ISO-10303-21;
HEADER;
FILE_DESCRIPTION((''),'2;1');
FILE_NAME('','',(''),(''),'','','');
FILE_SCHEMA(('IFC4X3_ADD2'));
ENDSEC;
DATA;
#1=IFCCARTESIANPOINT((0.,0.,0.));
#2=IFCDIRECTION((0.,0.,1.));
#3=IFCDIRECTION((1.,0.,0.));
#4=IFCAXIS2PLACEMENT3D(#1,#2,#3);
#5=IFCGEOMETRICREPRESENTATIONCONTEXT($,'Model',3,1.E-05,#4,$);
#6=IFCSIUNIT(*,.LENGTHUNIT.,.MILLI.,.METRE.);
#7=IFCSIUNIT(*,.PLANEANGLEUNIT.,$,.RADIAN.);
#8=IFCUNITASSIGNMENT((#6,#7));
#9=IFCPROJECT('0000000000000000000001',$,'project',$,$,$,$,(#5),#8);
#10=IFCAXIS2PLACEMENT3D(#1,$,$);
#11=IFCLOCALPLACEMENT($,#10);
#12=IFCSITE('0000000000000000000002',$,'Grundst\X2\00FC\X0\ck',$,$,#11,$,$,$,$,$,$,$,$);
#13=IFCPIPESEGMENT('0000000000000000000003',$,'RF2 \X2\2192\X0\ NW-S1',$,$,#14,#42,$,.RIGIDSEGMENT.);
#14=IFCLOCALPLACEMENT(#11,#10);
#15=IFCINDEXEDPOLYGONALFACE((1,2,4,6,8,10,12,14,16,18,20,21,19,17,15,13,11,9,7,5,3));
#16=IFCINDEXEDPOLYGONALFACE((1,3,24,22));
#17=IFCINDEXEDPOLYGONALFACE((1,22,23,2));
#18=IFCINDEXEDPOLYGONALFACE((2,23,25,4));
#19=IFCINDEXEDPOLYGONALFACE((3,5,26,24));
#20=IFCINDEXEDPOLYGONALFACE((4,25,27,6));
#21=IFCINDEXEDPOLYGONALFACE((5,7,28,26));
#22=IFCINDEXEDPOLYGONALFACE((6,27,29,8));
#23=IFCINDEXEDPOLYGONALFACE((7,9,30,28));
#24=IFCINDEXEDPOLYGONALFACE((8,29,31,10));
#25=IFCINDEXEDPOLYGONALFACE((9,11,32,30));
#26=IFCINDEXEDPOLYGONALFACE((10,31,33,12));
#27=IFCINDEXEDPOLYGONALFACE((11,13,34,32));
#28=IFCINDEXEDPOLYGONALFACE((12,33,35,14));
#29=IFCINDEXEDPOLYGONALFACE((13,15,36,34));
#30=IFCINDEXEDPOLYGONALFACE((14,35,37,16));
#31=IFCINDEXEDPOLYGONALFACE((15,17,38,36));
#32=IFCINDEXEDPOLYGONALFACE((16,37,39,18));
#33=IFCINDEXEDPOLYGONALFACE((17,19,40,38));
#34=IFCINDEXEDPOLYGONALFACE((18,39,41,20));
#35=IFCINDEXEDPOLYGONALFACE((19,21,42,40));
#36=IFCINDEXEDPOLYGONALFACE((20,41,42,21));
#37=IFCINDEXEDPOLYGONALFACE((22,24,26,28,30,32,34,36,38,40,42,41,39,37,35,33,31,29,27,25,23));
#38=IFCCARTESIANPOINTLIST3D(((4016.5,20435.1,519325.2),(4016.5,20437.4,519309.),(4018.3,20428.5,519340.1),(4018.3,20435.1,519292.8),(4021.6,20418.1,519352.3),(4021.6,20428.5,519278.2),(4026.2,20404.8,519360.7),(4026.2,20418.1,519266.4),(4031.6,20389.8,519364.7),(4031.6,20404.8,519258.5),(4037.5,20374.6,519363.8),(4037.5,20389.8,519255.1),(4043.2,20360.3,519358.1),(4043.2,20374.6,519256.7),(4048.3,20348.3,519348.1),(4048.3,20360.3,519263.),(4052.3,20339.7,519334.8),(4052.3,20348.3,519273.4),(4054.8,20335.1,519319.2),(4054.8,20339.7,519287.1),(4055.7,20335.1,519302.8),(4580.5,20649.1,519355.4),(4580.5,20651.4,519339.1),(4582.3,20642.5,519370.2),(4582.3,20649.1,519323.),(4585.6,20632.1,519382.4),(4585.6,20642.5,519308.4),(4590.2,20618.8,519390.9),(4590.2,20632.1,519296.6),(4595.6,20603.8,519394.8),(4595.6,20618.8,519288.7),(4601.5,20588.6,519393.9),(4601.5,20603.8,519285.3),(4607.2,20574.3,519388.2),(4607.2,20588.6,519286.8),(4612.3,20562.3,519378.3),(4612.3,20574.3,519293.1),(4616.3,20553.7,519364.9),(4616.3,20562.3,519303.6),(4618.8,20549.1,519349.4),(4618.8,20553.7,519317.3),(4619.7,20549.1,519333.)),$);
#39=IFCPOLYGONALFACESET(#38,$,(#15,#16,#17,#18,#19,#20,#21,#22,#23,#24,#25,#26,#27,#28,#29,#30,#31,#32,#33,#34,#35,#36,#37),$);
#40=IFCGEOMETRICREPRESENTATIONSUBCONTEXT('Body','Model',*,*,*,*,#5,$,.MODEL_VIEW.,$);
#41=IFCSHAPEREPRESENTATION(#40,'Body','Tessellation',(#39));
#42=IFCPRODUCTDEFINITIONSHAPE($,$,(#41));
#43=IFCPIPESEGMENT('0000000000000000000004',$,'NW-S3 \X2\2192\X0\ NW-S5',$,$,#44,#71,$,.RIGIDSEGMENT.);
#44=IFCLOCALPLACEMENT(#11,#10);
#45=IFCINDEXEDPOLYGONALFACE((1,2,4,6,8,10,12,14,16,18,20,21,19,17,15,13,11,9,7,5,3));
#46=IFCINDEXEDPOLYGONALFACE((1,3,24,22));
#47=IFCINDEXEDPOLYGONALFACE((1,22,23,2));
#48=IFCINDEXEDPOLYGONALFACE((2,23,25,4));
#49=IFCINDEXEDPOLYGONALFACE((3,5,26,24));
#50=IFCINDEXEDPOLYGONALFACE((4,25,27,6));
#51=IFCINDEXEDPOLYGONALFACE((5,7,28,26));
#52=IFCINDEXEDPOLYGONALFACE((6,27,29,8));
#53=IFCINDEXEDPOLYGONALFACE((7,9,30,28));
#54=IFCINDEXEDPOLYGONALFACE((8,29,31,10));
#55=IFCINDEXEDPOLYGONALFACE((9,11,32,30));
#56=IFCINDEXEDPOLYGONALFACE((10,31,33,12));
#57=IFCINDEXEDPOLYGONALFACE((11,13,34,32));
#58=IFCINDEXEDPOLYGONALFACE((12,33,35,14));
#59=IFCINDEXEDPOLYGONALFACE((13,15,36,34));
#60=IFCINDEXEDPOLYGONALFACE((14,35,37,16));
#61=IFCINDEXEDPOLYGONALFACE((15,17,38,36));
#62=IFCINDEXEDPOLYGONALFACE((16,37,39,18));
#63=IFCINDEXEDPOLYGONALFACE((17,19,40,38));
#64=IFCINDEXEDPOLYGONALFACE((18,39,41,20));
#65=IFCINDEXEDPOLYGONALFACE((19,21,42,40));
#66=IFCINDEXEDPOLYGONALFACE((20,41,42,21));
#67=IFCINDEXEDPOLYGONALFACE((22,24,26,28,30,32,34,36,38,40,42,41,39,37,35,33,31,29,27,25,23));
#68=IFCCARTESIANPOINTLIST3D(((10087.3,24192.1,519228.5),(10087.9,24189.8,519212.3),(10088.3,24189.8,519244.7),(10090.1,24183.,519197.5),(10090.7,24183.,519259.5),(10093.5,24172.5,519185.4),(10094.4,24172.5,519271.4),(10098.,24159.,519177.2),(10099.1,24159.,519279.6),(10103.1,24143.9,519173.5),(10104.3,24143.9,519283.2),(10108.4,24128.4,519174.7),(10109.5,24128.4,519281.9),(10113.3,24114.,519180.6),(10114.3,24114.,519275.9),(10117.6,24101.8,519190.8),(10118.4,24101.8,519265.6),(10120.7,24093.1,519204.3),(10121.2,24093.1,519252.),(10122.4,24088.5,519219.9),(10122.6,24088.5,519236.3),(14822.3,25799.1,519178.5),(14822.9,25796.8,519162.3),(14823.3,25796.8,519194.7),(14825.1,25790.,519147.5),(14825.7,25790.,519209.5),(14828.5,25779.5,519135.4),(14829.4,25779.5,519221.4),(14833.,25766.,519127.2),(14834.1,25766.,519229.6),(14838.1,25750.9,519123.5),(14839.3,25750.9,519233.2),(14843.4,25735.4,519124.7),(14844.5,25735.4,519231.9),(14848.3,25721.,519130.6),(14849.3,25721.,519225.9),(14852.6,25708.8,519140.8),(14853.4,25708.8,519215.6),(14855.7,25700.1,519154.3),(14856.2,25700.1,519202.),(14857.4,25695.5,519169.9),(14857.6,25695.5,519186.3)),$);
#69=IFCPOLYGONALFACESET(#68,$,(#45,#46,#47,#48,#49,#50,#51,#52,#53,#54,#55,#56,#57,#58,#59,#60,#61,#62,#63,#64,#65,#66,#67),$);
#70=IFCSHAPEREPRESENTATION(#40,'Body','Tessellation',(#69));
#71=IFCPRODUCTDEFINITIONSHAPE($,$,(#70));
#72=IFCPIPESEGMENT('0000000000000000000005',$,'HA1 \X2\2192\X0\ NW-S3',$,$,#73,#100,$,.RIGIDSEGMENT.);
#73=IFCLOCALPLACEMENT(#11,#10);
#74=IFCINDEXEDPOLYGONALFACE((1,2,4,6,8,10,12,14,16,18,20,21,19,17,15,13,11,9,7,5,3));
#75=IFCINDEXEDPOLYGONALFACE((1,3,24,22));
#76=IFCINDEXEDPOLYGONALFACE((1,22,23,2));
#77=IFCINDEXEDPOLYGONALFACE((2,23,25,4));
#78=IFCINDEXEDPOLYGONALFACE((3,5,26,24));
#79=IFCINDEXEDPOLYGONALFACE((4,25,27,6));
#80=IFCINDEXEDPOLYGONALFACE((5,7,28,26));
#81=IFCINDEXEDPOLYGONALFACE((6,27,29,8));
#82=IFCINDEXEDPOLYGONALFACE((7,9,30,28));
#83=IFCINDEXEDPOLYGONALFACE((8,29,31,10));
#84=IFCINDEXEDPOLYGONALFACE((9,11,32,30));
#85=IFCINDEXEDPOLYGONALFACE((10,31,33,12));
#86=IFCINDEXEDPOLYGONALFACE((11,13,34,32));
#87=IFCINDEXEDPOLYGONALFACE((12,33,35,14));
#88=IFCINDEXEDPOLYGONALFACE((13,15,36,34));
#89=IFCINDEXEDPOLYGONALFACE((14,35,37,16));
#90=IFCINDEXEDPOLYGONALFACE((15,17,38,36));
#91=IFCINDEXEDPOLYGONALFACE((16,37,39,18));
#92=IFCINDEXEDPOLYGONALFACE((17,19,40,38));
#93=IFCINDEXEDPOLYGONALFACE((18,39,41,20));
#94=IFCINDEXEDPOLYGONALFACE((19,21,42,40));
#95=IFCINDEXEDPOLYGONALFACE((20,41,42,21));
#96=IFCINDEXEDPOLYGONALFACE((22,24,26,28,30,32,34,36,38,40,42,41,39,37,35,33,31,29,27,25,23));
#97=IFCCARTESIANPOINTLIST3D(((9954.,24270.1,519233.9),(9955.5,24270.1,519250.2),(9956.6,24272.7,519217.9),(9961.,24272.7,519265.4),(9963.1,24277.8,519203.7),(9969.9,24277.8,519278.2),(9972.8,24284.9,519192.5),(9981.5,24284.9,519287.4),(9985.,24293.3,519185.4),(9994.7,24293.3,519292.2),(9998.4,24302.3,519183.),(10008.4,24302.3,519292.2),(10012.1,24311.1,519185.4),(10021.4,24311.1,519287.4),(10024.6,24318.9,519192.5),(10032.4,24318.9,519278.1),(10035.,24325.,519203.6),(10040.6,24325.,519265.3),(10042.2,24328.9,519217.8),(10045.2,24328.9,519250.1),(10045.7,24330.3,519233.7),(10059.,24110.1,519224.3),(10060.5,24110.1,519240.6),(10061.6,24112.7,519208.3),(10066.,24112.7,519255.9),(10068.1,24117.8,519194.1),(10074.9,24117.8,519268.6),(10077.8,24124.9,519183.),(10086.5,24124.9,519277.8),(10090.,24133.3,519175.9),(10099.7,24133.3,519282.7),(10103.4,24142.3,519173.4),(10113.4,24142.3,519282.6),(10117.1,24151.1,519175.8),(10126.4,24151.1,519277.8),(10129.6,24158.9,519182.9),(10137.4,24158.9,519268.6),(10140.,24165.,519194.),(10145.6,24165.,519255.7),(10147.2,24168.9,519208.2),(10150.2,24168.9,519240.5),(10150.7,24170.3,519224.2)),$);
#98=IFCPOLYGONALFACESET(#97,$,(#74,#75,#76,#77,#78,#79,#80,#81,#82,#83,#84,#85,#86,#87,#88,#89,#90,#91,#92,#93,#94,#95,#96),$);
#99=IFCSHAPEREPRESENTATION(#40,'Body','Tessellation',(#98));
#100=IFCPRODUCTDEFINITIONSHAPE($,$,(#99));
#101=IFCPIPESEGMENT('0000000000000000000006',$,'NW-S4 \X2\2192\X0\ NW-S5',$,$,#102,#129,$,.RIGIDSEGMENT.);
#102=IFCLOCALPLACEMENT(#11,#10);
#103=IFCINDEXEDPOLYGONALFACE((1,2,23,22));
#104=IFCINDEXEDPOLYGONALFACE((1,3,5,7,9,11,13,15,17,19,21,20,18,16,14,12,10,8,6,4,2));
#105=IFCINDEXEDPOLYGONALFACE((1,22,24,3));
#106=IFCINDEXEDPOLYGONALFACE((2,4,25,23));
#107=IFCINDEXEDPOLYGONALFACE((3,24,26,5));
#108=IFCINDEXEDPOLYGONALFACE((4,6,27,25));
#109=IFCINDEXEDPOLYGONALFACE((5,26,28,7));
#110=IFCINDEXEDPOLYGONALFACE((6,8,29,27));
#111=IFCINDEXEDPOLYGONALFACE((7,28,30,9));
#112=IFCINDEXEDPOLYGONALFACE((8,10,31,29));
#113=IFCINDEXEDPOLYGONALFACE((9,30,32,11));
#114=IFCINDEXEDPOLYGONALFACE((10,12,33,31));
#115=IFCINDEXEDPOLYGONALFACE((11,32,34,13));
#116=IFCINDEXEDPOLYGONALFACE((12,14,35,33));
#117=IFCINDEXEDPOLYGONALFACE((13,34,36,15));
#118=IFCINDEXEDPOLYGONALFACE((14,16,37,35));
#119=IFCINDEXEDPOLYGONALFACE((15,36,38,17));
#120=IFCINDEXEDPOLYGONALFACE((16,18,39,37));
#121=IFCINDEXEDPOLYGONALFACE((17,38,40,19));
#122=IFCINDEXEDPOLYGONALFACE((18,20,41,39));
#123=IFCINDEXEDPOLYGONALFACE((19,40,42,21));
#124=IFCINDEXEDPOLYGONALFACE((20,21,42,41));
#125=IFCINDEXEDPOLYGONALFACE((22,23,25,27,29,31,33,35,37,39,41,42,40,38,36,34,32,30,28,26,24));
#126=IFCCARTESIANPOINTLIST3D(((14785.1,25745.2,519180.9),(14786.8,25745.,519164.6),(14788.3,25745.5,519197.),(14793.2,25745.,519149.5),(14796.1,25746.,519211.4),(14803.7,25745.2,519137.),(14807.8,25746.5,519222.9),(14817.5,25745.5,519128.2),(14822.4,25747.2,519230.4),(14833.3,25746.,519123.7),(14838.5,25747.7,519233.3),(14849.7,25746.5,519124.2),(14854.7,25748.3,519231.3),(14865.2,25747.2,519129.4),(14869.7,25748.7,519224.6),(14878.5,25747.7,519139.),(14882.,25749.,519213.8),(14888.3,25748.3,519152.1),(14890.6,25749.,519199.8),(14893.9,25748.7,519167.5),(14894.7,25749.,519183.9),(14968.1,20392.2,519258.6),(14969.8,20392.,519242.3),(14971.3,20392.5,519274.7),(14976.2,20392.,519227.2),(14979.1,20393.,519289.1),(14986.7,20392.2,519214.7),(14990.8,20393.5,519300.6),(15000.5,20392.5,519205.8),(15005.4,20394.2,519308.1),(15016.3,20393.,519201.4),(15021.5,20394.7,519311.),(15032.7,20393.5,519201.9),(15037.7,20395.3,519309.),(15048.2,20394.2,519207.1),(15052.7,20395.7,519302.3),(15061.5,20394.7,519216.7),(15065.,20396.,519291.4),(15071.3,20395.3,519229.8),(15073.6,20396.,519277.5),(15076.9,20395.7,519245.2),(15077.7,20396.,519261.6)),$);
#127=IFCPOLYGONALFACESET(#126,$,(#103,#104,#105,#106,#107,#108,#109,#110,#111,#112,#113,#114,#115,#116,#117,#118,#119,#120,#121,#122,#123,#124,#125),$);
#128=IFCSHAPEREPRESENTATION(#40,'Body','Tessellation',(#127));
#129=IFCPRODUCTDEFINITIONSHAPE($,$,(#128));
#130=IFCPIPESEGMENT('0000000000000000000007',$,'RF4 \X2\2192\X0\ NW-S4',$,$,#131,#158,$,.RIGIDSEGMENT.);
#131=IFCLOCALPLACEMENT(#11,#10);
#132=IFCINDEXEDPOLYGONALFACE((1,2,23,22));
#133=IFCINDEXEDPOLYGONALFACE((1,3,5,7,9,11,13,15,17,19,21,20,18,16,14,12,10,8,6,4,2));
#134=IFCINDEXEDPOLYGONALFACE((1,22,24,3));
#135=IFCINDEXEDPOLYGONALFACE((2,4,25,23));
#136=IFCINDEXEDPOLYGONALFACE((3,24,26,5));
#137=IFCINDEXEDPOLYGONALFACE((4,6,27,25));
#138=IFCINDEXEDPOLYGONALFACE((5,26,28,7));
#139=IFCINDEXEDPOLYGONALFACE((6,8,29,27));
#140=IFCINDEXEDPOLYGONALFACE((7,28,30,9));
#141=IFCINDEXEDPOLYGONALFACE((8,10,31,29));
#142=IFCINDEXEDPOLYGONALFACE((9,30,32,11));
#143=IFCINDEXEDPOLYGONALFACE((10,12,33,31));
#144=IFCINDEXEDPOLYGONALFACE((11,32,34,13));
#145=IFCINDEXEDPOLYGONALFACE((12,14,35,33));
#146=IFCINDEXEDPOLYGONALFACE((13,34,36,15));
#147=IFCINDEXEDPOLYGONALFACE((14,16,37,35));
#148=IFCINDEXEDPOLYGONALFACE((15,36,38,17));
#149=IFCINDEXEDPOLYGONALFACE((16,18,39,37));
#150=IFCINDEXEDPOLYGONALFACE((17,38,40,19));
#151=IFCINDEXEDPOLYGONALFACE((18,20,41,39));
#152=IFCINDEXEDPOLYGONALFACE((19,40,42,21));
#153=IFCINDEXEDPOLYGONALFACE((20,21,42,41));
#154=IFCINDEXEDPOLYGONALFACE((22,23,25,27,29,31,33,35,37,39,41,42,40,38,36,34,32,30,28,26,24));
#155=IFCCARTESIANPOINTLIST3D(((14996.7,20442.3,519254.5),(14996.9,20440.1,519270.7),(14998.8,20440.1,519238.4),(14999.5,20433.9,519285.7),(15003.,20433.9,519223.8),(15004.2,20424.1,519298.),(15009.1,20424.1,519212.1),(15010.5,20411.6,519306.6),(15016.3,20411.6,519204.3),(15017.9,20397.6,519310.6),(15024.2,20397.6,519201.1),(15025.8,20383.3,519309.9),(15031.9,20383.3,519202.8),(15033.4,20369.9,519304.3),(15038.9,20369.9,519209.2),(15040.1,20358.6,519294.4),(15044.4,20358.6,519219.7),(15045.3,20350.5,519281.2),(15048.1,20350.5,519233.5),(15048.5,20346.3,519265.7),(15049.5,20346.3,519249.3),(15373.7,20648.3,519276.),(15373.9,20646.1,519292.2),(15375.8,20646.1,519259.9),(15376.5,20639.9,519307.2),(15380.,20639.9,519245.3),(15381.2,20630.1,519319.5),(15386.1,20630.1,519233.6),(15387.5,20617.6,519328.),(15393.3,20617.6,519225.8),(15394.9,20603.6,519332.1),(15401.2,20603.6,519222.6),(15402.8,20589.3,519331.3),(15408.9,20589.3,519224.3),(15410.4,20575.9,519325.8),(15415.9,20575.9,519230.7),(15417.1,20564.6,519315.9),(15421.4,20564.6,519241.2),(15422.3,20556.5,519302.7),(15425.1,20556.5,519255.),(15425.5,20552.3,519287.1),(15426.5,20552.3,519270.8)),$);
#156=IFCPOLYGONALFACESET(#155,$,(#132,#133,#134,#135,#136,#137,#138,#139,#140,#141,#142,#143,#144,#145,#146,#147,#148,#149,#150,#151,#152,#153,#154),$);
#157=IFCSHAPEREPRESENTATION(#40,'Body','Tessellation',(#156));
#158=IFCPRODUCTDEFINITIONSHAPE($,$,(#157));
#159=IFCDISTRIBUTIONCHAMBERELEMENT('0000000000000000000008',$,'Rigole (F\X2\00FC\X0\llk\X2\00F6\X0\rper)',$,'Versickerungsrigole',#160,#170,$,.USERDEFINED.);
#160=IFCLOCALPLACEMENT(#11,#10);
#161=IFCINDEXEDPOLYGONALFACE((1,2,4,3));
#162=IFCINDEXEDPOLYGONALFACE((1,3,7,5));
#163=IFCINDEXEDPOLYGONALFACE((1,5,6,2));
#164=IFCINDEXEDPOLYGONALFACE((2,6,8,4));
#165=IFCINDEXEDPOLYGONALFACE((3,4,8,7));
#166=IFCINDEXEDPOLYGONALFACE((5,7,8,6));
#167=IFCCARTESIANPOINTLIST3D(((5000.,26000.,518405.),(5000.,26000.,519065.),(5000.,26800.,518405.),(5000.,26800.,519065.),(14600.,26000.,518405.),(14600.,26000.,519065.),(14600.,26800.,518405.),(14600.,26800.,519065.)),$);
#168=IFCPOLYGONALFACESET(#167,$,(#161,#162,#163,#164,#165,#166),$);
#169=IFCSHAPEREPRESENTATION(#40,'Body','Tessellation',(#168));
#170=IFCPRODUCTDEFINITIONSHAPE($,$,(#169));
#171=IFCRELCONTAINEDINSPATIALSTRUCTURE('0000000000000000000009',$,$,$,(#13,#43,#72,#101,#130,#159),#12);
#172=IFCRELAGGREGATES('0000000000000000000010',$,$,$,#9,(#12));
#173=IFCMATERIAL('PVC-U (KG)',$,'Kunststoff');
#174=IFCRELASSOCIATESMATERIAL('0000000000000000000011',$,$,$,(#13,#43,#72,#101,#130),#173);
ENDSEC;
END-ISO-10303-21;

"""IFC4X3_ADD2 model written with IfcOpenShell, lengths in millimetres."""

from ifc_helpers import new_model, si_unit, frame, frame_2d, origin, origin_with_axes, place, context, subcontext, project, spatial, rectangle, circle, extrude, material, element, save


model = new_model("IFC4X3_ADD2")

# Units and contexts
model_context = context("Model", 3, precision=1e-05, world=origin_with_axes())
body_context = subcontext(model_context, "Body", "Model", "MODEL_VIEW")
ifc_project = project(units=[si_unit("LENGTHUNIT", "METRE", prefix="MILLI"), si_unit("PLANEANGLEUNIT", "RADIAN")], contexts=[model_context])

# Site
site_placement = place(None, origin())
site = spatial("IfcSite", under=ifc_project, at=site_placement, Name="Grundstück")

# Shared definitions
ifc_material = material(Name="PVC-U (KG)", Category="Kunststoff")

# Pipe segments
pipe_segment_1_placement = place(site_placement, frame((4600.0, 20600.0, 519285.2)))
element("IfcPipeSegment", 1, at=pipe_segment_1_placement, inside=site, material=ifc_material, Name="RF2 → NW-S1", PredefinedType="RIGIDSEGMENT", context=body_context, shape_type="SweptSolid", body=[
    extrude(circle(Radius=55.0), frame((0.0, 0.0, 55.0), z_axis=(-0.933793, -0.354312, -0.049938), x_axis=(0.0, 1.0, 0.0)), (0.0, 0.0, 1.0), 604.0),
])
pipe_segment_2_placement = place(site_placement, frame((10105.0, 24140.0, 519173.3)))
element("IfcPipeSegment", 2, at=pipe_segment_2_placement, inside=site, material=ifc_material, Name="NW-S3 → NW-S5", PredefinedType="RIGIDSEGMENT", context=body_context, shape_type="SweptSolid", body=[
    extrude(circle(Radius=55.0), frame((0.0, 0.0, 55.0), z_axis=(0.946902, 0.321367, -0.01), x_axis=(0.0, 1.0, 0.0)), (0.0, 0.0, 1.0), 5000.5),
])
pipe_segment_3_placement = place(site_placement, frame((10000.0, 24300.0, 519182.9)))
element("IfcPipeSegment", 3, at=pipe_segment_3_placement, inside=site, material=ifc_material, Name="HA1 → NW-S3", PredefinedType="RIGIDSEGMENT", context=body_context, shape_type="SweptSolid", body=[
    extrude(circle(Radius=55.0), frame((0.0, 0.0, 55.0), z_axis=(0.547972, -0.835005, -0.049938), x_axis=(0.0, 1.0, 0.0)), (0.0, 0.0, 1.0), 191.6),
])
pipe_segment_4_placement = place(site_placement, frame((15023.0, 20394.0, 519201.0)))
element("IfcPipeSegment", 4, at=pipe_segment_4_placement, inside=site, material=ifc_material, Name="NW-S4 → NW-S5", PredefinedType="RIGIDSEGMENT", context=body_context, shape_type="SweptSolid", body=[
    extrude(circle(Radius=55.0), frame((0.0, 0.0, 55.0), z_axis=(-0.034163, 0.999311, -0.014499), x_axis=(0.0, 1.0, 0.0)), (0.0, 0.0, 1.0), 5356.7),
])
pipe_segment_5_placement = place(site_placement, frame((15400.0, 20600.0, 519222.5)))
element("IfcPipeSegment", 5, at=pipe_segment_5_placement, inside=site, material=ifc_material, Name="RF4 → NW-S4", PredefinedType="RIGIDSEGMENT", context=body_context, shape_type="SweptSolid", body=[
    extrude(circle(Radius=55.0), frame((0.0, 0.0, 55.0), z_axis=(-0.876445, -0.478906, -0.049938), x_axis=(0.0, 1.0, 0.0)), (0.0, 0.0, 1.0), 430.1),
])

# Distribution chamber element
distribution_chamber_element_1_placement = place(site_placement, frame((5000.0, 26000.0, 518405.0)))
element("IfcDistributionChamberElement", 6, at=distribution_chamber_element_1_placement, inside=site, Name="Rigole (Füllkörper)", ObjectType="Versickerungsrigole", PredefinedType="USERDEFINED", context=body_context, shape_type="SweptSolid", body=[
    extrude(rectangle(XDim=9600.0, YDim=800.0, at=frame_2d((4800.0, 400.0))), origin(), (0.0, 0.0, 1.0), 660.0),
])

save(model, "model.ifc")
